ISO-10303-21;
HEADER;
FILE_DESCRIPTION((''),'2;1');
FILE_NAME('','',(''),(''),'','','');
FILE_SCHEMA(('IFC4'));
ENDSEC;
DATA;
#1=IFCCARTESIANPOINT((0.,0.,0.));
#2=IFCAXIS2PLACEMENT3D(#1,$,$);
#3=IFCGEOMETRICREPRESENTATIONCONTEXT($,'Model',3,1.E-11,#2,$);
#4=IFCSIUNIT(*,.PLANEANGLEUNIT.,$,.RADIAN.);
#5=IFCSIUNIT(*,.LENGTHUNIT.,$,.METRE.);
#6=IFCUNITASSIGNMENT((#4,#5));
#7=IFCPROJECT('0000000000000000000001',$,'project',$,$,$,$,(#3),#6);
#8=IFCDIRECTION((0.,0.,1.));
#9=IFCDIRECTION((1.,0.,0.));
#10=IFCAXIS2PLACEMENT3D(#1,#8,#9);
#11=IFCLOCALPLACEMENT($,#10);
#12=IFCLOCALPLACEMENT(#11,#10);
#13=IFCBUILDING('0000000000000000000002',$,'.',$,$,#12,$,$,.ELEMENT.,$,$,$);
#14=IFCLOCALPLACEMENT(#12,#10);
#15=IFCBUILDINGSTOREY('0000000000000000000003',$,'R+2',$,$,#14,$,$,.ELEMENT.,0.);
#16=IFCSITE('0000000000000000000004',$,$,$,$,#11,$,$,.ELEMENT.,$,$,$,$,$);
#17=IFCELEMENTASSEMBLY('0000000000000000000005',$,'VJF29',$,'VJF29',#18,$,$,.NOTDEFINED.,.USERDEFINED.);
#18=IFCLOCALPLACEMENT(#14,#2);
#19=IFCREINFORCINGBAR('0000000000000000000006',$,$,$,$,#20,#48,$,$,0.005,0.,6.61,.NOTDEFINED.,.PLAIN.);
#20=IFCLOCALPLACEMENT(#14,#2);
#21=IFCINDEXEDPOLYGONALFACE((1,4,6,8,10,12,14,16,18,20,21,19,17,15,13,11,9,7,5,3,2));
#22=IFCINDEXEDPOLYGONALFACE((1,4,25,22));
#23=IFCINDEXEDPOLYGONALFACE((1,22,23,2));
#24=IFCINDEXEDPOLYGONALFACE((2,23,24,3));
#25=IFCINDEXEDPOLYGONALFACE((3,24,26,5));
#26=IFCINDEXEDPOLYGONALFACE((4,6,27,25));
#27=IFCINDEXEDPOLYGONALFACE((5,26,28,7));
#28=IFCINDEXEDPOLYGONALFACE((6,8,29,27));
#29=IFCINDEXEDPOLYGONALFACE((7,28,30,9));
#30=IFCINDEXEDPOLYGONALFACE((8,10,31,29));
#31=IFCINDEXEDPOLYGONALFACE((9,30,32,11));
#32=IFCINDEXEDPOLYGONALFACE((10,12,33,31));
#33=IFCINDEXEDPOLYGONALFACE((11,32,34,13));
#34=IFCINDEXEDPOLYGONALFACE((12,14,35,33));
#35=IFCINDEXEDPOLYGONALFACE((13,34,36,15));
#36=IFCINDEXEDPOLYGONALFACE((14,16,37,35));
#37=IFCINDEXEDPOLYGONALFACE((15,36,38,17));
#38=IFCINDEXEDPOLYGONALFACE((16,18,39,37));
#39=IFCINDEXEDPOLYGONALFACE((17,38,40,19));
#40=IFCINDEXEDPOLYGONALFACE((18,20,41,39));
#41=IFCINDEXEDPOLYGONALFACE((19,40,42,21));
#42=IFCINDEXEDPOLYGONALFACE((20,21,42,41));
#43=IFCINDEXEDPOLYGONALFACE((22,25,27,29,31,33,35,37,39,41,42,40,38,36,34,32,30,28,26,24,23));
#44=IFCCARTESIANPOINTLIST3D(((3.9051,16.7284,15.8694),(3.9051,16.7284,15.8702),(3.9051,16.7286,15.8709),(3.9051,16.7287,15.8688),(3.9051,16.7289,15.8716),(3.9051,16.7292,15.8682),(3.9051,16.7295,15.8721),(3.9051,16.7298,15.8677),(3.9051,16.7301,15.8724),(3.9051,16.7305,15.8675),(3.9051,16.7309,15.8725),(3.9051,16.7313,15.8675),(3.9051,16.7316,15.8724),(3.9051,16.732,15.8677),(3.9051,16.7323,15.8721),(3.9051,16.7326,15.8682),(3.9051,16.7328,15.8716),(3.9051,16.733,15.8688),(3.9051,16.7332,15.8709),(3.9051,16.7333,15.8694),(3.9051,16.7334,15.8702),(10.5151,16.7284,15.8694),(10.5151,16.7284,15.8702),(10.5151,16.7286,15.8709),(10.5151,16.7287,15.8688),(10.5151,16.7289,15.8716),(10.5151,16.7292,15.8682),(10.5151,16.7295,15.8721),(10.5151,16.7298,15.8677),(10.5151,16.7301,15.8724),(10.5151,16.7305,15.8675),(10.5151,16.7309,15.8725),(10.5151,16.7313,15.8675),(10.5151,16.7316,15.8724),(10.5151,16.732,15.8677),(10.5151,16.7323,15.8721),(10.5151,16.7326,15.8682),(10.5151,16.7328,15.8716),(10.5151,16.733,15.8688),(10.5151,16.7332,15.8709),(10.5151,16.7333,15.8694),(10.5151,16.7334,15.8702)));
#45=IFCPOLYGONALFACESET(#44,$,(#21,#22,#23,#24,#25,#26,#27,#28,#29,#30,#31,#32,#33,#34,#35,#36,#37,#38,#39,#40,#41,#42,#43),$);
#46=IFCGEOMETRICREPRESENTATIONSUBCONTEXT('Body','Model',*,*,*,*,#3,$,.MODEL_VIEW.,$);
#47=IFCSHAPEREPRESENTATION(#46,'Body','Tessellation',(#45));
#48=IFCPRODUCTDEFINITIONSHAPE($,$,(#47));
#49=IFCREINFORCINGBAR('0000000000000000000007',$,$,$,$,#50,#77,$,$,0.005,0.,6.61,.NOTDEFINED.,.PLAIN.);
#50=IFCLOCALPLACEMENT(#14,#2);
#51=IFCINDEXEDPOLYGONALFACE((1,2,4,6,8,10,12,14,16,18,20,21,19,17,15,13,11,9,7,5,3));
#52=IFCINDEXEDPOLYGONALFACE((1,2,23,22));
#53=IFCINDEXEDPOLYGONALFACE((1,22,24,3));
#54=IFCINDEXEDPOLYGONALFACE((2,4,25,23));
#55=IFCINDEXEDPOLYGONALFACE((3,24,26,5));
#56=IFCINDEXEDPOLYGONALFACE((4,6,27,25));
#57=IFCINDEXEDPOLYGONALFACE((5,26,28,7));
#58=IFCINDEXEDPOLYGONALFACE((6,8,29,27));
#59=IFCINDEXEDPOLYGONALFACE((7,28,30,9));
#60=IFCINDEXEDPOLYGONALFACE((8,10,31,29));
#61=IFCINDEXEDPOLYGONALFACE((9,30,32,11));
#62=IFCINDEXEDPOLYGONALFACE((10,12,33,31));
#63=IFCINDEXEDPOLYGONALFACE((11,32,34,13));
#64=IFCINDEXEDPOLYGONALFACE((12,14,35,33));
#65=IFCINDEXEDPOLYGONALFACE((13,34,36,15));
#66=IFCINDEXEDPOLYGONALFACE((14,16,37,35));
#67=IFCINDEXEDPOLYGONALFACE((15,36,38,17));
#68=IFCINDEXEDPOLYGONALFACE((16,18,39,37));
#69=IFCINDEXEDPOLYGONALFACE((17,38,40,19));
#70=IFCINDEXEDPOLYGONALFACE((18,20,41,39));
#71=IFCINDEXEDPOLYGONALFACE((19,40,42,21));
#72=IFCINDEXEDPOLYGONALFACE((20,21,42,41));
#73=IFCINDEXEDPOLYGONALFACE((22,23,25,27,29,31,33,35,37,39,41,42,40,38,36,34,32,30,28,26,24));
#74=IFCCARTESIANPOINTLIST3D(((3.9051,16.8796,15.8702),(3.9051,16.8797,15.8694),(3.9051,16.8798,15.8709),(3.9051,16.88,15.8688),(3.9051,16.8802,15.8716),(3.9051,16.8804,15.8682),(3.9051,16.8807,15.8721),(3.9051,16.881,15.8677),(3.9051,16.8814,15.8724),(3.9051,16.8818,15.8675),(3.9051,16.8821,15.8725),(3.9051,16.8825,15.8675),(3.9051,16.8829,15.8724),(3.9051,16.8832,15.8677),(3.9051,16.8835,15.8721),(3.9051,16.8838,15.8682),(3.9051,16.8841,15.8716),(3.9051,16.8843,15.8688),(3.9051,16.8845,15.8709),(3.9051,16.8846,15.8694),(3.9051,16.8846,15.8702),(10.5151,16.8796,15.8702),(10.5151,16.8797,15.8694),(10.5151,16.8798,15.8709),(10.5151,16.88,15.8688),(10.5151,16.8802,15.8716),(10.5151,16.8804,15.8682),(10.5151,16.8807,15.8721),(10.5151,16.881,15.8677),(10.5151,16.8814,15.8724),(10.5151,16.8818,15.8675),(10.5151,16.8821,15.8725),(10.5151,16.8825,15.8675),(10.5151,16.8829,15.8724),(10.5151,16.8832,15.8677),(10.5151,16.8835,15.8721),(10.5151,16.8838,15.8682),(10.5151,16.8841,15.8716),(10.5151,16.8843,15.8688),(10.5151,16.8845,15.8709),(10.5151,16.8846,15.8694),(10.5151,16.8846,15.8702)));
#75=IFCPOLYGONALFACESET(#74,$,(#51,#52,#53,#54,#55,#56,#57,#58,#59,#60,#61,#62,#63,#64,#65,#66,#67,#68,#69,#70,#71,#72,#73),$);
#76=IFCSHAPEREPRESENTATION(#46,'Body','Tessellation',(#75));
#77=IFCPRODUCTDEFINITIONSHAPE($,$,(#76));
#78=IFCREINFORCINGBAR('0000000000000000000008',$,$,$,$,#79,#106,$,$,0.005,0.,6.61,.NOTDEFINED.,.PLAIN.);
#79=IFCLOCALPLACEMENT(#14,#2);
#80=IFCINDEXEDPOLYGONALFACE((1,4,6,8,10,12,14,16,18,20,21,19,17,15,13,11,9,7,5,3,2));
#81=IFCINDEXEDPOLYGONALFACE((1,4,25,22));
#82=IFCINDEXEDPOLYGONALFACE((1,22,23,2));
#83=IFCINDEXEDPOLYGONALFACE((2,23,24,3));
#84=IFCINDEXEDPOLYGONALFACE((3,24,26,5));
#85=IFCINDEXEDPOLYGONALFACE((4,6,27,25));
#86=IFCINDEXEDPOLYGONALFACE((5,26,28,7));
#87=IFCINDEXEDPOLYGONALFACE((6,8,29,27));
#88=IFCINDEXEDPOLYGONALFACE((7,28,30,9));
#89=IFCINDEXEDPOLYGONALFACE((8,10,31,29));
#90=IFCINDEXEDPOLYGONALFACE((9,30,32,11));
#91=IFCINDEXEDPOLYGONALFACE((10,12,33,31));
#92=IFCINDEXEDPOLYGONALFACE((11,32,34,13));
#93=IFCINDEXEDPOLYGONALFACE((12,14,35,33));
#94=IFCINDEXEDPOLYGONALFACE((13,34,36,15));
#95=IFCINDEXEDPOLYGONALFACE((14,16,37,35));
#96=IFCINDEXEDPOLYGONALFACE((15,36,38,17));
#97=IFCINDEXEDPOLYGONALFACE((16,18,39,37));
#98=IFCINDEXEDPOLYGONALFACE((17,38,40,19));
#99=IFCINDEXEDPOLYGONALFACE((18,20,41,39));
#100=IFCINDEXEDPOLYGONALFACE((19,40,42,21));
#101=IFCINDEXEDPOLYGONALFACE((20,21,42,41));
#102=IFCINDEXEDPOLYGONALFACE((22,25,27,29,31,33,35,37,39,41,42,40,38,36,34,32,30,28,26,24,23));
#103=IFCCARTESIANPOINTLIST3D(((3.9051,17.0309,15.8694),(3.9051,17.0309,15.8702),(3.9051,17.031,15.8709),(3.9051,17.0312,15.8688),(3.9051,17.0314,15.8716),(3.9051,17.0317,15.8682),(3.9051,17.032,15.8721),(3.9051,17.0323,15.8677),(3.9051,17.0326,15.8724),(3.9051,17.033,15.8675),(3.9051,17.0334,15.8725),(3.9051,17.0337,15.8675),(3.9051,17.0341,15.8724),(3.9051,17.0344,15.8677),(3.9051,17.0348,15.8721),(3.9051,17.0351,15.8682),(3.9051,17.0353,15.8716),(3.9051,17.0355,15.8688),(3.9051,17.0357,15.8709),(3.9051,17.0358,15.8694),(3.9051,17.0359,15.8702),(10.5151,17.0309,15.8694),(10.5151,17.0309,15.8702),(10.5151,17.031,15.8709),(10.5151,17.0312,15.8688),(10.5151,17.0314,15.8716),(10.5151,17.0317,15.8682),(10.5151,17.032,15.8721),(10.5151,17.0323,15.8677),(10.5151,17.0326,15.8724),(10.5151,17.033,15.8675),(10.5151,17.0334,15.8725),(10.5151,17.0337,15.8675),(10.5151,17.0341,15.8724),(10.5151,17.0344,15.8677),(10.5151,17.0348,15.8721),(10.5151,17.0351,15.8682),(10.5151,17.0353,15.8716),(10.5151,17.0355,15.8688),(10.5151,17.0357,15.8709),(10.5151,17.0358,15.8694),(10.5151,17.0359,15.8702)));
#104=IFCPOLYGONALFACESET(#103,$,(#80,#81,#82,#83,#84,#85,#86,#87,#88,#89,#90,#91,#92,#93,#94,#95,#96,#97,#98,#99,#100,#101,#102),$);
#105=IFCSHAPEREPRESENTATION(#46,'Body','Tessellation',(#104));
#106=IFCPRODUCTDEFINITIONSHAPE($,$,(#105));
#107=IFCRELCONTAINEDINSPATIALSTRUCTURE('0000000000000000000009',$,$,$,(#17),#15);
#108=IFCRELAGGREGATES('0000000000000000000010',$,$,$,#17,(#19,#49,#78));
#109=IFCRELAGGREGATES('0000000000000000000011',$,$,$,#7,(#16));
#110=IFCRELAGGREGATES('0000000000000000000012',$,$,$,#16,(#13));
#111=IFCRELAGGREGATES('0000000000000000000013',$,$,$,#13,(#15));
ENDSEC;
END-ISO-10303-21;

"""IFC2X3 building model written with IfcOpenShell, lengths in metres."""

from ifc_helpers import new_model, entity, si_unit, origin, origin_with_axes, place, context, subcontext, project, spatial, shape, element, aggregate, save


model = new_model("IFC2X3")

# Units and contexts
model_context = context("Model", 3, precision=1e-11, world=origin())
body_context = subcontext(model_context, "Body", "Model", "MODEL_VIEW")
ifc_project = project(units=[si_unit("PLANEANGLEUNIT", "RADIAN"), si_unit("LENGTHUNIT", "METRE")], contexts=[model_context])

# Site, building, storey
site_placement = place(None, origin_with_axes())
site = spatial("IfcSite", under=ifc_project, at=site_placement, CompositionType="ELEMENT")
building_placement = place(site_placement, origin_with_axes())
building = spatial("IfcBuilding", under=site, at=building_placement, Name=".", CompositionType="ELEMENT")
storey_placement = place(building_placement, origin_with_axes())
storey = spatial("IfcBuildingStorey", under=building, at=storey_placement, Name="R+2", CompositionType="ELEMENT", Elevation=0.0)

# Element assembly, reinforcing bars
assembly_1_placement = place(storey_placement, origin_with_axes())
assembly_1 = element("IfcElementAssembly", 1, at=assembly_1_placement, inside=storey, Name="VJF29", ObjectType="VJF29", AssemblyPlace="NOTDEFINED", PredefinedType="USERDEFINED")
reinforcing_bar_1_placement = place(assembly_1_placement, origin_with_axes())
reinforcing_bar_1 = element("IfcReinforcingBar", 2, at=reinforcing_bar_1_placement, BarLength=6.61, BarRole="NOTDEFINED", BarSurface="PLAIN", CrossSectionArea=0.0, NominalDiameter=0.005, shapes=[
    shape(body_context, "Body", "AdvancedSweptSolid", [entity("IfcSweptDiskSolid", entity("IfcPolyline", [entity("IfcCartesianPoint", [3.9051, 16.7309, 15.87]), entity("IfcCartesianPoint", [10.5151, 16.7309, 15.87])]), 0.0025, None, 0.0, 6.61)]),
    shape(body_context, "Body", "AdvancedSweptSolid", [entity("IfcSweptDiskSolid", entity("IfcPolyline", [entity("IfcCartesianPoint", [3.9051, 16.7309, 15.87]), entity("IfcCartesianPoint", [10.5151, 16.7309, 15.87])]), 0.0025, None, 0.0, 6.61)]),
])
reinforcing_bar_2_placement = place(assembly_1_placement, origin_with_axes())
reinforcing_bar_2 = element("IfcReinforcingBar", 3, at=reinforcing_bar_2_placement, BarLength=6.61, BarRole="NOTDEFINED", BarSurface="PLAIN", CrossSectionArea=0.0, NominalDiameter=0.005, shapes=[
    shape(body_context, "Body", "AdvancedSweptSolid", [entity("IfcSweptDiskSolid", entity("IfcPolyline", [entity("IfcCartesianPoint", [3.9051, 16.8821, 15.87]), entity("IfcCartesianPoint", [10.5151, 16.8821, 15.87])]), 0.0025, None, 0.0, 6.61)]),
    shape(body_context, "Body", "AdvancedSweptSolid", [entity("IfcSweptDiskSolid", entity("IfcPolyline", [entity("IfcCartesianPoint", [3.9051, 16.8821, 15.87]), entity("IfcCartesianPoint", [10.5151, 16.8821, 15.87])]), 0.0025, None, 0.0, 6.61)]),
])
reinforcing_bar_3_placement = place(assembly_1_placement, origin_with_axes())
reinforcing_bar_3 = element("IfcReinforcingBar", 4, at=reinforcing_bar_3_placement, BarLength=6.61, BarRole="NOTDEFINED", BarSurface="PLAIN", CrossSectionArea=0.0, NominalDiameter=0.005, shapes=[
    shape(body_context, "Body", "AdvancedSweptSolid", [entity("IfcSweptDiskSolid", entity("IfcPolyline", [entity("IfcCartesianPoint", [3.9051, 17.0334, 15.87]), entity("IfcCartesianPoint", [10.5151, 17.0334, 15.87])]), 0.0025, None, 0.0, 6.61)]),
    shape(body_context, "Body", "AdvancedSweptSolid", [entity("IfcSweptDiskSolid", entity("IfcPolyline", [entity("IfcCartesianPoint", [3.9051, 17.0334, 15.87]), entity("IfcCartesianPoint", [10.5151, 17.0334, 15.87])]), 0.0025, None, 0.0, 6.61)]),
])
aggregate(assembly_1, [reinforcing_bar_1, reinforcing_bar_2, reinforcing_bar_3])

save(model, "model.ifc")
